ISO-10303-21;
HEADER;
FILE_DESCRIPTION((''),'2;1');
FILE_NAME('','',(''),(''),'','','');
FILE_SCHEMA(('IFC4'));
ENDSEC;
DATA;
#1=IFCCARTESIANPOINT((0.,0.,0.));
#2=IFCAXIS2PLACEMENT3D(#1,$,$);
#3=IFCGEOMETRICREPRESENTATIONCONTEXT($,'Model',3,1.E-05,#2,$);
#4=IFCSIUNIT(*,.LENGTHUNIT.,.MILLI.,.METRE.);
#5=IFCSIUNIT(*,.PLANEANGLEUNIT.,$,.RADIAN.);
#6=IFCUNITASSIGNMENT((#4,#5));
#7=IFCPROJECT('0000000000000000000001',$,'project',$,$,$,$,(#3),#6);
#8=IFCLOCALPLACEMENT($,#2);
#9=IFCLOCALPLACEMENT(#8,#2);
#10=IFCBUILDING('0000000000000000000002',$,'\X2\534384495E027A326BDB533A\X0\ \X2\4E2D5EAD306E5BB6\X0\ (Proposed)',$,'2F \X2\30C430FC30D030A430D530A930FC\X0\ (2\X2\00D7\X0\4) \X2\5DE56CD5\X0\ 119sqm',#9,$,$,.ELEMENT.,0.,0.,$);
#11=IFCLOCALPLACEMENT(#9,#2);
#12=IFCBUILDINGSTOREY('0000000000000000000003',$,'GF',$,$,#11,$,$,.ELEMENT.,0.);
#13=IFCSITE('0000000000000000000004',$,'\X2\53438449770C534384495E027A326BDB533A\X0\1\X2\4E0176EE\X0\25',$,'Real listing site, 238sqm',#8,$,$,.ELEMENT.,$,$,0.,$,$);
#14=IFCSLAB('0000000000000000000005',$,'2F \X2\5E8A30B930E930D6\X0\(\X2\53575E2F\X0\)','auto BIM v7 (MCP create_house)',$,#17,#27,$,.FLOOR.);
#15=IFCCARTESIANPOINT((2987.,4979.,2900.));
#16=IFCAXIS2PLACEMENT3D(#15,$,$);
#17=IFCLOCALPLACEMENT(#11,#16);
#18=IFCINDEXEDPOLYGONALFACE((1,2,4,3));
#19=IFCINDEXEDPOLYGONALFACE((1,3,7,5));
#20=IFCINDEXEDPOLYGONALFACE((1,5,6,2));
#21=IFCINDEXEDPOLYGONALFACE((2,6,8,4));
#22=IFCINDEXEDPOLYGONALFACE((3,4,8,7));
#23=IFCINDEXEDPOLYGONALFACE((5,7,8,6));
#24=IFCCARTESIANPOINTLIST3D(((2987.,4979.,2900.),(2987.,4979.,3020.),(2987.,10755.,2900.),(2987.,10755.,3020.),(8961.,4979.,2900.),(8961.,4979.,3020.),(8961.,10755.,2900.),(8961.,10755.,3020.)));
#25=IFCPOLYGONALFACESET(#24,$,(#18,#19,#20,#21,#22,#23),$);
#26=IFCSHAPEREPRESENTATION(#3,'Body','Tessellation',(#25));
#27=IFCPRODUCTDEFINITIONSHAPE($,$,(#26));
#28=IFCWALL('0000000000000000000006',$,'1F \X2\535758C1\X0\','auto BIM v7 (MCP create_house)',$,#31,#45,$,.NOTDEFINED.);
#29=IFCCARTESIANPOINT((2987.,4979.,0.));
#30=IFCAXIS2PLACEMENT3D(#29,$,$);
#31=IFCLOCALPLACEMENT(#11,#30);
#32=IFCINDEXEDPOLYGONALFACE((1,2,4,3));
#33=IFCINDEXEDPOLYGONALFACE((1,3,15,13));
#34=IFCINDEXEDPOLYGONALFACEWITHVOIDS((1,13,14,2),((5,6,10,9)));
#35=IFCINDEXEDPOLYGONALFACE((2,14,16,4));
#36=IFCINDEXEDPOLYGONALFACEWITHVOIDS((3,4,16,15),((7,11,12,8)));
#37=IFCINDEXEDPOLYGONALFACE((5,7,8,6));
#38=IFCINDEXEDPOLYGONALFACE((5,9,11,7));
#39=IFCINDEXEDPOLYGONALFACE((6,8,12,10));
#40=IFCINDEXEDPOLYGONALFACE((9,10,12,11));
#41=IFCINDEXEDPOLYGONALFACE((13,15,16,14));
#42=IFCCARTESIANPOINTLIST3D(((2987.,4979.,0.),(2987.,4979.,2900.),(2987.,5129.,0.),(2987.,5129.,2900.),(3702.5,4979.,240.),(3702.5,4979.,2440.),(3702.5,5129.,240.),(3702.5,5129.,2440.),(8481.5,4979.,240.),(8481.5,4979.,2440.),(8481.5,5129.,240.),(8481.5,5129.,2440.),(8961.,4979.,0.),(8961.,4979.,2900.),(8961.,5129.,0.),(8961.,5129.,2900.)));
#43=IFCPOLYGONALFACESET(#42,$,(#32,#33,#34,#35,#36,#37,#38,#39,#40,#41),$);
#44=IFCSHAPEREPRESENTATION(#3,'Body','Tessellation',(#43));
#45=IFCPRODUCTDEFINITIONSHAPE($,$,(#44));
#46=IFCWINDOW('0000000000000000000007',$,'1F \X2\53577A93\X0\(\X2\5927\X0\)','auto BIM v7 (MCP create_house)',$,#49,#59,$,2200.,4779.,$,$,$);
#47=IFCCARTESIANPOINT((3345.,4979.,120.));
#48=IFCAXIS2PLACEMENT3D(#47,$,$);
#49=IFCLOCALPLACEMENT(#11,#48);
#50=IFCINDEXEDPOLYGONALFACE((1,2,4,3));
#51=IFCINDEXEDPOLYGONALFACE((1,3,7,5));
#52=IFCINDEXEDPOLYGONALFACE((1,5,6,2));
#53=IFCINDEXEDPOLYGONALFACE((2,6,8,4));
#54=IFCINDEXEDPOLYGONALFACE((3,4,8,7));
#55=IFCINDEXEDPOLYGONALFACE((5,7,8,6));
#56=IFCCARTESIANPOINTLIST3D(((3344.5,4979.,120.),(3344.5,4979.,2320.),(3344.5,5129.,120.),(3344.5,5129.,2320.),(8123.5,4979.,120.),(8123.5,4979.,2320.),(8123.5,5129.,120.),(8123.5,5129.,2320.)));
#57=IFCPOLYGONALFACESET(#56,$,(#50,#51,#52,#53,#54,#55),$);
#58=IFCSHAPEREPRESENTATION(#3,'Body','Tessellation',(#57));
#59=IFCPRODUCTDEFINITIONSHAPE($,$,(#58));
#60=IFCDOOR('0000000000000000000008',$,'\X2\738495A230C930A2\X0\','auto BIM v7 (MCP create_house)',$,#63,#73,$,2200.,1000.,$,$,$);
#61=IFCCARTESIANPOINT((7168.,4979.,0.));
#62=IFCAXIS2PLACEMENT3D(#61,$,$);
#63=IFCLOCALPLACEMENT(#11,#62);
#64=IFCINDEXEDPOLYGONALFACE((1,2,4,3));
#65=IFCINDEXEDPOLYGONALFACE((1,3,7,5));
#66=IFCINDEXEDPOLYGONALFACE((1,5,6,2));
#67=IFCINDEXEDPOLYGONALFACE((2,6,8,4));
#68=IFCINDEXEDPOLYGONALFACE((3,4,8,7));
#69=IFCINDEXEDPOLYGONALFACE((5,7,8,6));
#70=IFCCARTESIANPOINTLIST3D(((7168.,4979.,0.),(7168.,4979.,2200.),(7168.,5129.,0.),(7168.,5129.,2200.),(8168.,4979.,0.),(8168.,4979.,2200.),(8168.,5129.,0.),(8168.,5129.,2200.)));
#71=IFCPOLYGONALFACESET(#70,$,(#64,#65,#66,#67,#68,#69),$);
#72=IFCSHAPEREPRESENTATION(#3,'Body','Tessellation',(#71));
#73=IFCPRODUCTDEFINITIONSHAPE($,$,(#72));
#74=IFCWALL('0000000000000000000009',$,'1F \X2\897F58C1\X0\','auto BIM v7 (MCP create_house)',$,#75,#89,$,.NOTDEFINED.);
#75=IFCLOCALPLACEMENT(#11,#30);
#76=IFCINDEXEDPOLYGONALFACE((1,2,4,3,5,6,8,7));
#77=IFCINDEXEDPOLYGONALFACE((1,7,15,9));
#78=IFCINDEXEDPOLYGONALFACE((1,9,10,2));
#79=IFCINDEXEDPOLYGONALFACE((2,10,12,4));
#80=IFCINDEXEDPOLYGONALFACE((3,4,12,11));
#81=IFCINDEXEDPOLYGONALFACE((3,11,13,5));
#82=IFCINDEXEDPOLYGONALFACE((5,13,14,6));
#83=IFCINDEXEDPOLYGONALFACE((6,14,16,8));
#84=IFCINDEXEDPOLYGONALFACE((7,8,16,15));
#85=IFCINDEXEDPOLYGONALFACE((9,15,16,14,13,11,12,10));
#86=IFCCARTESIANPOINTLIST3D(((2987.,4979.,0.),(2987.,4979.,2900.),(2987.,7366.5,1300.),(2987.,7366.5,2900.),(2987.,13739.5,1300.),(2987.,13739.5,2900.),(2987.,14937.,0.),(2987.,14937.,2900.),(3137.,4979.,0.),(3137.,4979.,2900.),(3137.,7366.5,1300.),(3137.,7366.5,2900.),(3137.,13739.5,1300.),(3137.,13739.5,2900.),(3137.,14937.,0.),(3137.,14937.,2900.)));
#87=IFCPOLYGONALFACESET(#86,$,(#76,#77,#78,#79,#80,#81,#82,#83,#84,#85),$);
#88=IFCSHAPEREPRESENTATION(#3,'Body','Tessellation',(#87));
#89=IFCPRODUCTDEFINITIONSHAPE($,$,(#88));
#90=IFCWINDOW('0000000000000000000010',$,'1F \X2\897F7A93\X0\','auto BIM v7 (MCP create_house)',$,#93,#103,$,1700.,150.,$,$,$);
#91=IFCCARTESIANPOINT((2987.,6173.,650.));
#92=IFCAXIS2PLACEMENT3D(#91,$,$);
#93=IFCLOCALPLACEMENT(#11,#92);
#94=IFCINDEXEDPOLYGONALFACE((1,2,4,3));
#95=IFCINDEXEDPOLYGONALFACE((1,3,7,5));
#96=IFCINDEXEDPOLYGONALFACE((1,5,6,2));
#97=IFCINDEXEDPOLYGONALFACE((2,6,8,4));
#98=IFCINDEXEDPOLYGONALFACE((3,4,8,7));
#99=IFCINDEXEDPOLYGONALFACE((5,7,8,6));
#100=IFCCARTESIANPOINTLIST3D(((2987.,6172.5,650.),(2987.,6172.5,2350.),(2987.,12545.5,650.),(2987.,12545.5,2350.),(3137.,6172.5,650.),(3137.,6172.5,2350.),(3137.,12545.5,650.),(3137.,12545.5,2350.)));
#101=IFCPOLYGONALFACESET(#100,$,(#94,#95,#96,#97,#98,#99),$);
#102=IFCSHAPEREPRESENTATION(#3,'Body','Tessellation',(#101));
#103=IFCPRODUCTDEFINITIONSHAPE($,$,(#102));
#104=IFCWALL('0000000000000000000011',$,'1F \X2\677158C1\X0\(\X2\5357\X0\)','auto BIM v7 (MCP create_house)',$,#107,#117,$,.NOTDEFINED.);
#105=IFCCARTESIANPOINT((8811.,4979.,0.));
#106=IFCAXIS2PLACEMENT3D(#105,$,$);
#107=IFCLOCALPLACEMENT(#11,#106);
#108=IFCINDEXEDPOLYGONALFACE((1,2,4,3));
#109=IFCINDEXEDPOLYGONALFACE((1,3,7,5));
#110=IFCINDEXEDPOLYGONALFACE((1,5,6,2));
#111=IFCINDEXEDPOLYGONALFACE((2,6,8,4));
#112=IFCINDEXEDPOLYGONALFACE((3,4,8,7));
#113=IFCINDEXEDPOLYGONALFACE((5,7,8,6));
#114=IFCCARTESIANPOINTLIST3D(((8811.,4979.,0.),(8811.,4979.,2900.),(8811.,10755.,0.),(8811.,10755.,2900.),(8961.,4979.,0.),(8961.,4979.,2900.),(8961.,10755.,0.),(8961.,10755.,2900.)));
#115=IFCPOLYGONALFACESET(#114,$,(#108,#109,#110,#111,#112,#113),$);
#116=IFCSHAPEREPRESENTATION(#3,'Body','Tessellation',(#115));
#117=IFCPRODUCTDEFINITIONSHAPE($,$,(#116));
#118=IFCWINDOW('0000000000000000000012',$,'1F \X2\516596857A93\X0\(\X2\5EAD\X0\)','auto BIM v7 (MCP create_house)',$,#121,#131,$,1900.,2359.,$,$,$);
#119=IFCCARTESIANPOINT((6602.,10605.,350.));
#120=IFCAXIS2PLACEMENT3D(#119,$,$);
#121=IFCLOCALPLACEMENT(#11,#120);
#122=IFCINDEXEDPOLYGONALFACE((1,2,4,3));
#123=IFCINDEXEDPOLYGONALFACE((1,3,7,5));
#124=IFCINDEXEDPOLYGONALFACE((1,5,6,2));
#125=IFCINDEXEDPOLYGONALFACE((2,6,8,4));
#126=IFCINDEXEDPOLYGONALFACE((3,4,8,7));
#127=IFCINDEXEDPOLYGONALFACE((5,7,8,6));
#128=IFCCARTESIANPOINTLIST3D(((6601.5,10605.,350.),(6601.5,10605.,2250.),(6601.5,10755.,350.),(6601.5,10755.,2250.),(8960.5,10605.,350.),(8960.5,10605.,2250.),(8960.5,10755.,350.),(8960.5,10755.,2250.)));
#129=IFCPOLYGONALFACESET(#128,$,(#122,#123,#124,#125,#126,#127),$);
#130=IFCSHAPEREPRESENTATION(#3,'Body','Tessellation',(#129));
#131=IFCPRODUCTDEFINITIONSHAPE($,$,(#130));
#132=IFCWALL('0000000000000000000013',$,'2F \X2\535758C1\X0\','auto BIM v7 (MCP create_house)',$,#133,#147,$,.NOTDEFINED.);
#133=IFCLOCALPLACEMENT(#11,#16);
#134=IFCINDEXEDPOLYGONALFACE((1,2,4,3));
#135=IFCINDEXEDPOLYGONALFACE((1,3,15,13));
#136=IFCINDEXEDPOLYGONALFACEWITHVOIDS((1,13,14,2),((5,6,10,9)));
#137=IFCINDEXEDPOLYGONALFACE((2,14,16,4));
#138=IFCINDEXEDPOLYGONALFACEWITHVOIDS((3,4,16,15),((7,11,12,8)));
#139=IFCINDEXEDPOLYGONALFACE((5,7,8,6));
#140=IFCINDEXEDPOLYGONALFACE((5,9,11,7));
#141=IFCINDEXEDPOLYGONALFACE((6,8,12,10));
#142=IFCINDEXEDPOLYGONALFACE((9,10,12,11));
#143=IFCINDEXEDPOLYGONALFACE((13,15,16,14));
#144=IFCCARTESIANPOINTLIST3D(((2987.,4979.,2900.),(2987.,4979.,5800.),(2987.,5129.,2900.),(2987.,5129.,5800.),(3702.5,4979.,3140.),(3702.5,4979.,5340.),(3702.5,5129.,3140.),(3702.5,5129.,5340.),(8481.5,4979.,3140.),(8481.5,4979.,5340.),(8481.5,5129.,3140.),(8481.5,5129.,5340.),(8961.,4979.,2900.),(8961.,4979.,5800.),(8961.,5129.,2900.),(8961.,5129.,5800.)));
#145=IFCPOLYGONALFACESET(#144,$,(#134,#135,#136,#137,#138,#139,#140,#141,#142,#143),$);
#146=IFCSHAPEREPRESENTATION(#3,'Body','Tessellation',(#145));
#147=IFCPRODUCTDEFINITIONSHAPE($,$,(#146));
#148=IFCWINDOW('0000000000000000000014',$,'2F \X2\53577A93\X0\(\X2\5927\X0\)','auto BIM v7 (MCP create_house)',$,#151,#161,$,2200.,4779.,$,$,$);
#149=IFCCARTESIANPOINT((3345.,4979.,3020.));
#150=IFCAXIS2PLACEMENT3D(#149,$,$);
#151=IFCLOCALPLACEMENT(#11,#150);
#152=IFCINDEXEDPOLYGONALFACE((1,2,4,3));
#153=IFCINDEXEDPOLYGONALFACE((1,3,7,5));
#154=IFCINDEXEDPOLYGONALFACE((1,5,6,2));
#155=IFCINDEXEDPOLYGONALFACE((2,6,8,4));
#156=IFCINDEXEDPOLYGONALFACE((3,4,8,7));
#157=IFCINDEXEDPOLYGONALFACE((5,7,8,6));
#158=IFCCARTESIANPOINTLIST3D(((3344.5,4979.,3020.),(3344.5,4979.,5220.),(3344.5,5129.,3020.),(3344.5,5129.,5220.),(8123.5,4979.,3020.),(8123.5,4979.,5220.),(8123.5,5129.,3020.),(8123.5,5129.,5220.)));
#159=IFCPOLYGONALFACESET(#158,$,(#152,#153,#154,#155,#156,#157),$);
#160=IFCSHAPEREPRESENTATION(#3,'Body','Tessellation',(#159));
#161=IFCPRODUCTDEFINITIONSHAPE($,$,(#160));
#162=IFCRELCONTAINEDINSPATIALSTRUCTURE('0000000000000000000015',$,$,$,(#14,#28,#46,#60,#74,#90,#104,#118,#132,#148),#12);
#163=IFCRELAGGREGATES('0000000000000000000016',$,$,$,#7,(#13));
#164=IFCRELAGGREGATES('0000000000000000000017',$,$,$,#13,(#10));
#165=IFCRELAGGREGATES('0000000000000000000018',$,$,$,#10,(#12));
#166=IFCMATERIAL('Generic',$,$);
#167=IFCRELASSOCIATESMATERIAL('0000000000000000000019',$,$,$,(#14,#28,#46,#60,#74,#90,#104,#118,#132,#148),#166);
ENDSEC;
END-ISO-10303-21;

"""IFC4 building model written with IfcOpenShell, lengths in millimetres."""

from ifc_helpers import new_model, si_unit, frame, frame_2d, origin, place, context, project, spatial, rectangle, extrude, material, element, fill, save


model = new_model("IFC4")

# Units and contexts
model_context = context("Model", 3, precision=1e-05, world=origin())
ifc_project = project(units=[si_unit("LENGTHUNIT", "METRE", prefix="MILLI"), si_unit("PLANEANGLEUNIT", "RADIAN")], contexts=[model_context])

# Site, building, storey
site_placement = place(None, origin())
site = spatial("IfcSite", under=ifc_project, at=site_placement, Name="千葉県千葉市稲毛区1丁目25", ObjectType="Real listing site, 238sqm", CompositionType="ELEMENT", RefElevation=0.0)
building_placement = place(site_placement, origin())
building = spatial("IfcBuilding", under=site, at=building_placement, Name="千葉市稲毛区 中庭の家 (Proposed)", ObjectType="2F ツーバイフォー (2×4) 工法 119sqm", CompositionType="ELEMENT", ElevationOfRefHeight=0.0, ElevationOfTerrain=0.0)
storey_placement = place(building_placement, origin())
storey = spatial("IfcBuildingStorey", under=building, at=storey_placement, Name="GF", CompositionType="ELEMENT", Elevation=0.0)

# Slab
ifc_material = material(Name="Generic")
slab_1_placement = place(storey_placement, frame((2987.0, 4979.0, 2900.0)))
element("IfcSlab", 1, at=slab_1_placement, inside=storey, material=ifc_material, Name="2F 床スラブ(南帯)", Description="auto BIM v7 (MCP create_house)", PredefinedType="FLOOR", context=model_context, shape_type="SweptSolid", body=[
    extrude(rectangle(XDim=5974.0, YDim=5776.0, at=frame_2d((2987.0, 2888.0))), frame((2987.0, 4979.0, 2900.0)), (0.0, 0.0, 1.0), 120.0),
])

# Wall, openings, window, door
wall_1_placement = place(storey_placement, frame((2987.0, 4979.0, 0.0)))
wall_1 = element("IfcWall", 2, at=wall_1_placement, inside=storey, material=ifc_material, Name="1F 南壁", Description="auto BIM v7 (MCP create_house)", PredefinedType="NOTDEFINED", context=model_context, shape_type="SweptSolid", body=[
    extrude(rectangle(XDim=5974.0, YDim=150.0, at=frame_2d((2987.0, 75.0))), frame((2987.0, 4979.0, 0.0)), (0.0, 0.0, 1.0), 2900.0),
])
opening_1_placement = place(storey_placement, frame((3345.0, 4979.0, 120.0)))
opening_1 = element("IfcOpeningElement", 3, at=opening_1_placement, cuts=wall_1, PredefinedType="NOTDEFINED", context=model_context, shape_type="SweptSolid", body=[
    extrude(rectangle(XDim=4779.0, YDim=150.0, at=frame_2d((2389.0, 75.0))), frame((3345.0, 4979.0, 120.0)), (0.0, 0.0, 1.0), 2200.0),
])
opening_2_placement = place(storey_placement, frame((7168.0, 4979.0, 0.0)))
opening_2 = element("IfcOpeningElement", 4, at=opening_2_placement, cuts=wall_1, PredefinedType="NOTDEFINED", context=model_context, shape_type="SweptSolid", body=[
    extrude(rectangle(XDim=1000.0, YDim=150.0, at=frame_2d((500.0, 75.0))), frame((7168.0, 4979.0, 0.0)), (0.0, 0.0, 1.0), 2200.0),
])
window_1_placement = place(storey_placement, frame((3345.0, 4979.0, 120.0)))
window_1 = element("IfcWindow", 5, at=window_1_placement, inside=storey, material=ifc_material, Name="1F 南窓(大)", Description="auto BIM v7 (MCP create_house)", OverallHeight=2200.0, OverallWidth=4779.0, context=model_context, shape_type="SweptSolid", body=[
    extrude(rectangle(XDim=4779.0, YDim=150.0, at=frame_2d((2389.0, 75.0))), frame((3345.0, 4979.0, 120.0)), (0.0, 0.0, 1.0), 2200.0),
])
fill(opening_1, window_1)
door_placement = place(storey_placement, frame((7168.0, 4979.0, 0.0)))
door = element("IfcDoor", 6, at=door_placement, inside=storey, material=ifc_material, Name="玄関ドア", Description="auto BIM v7 (MCP create_house)", OverallHeight=2200.0, OverallWidth=1000.0, context=model_context, shape_type="SweptSolid", body=[
    extrude(rectangle(XDim=1000.0, YDim=150.0, at=frame_2d((500.0, 75.0))), frame((7168.0, 4979.0, 0.0)), (0.0, 0.0, 1.0), 2200.0),
])
fill(opening_2, door)

# Walls, openings, windows
wall_2_placement = place(storey_placement, frame((2987.0, 4979.0, 0.0)))
wall_2 = element("IfcWall", 7, at=wall_2_placement, inside=storey, material=ifc_material, Name="1F 西壁", Description="auto BIM v7 (MCP create_house)", PredefinedType="NOTDEFINED", context=model_context, shape_type="SweptSolid", body=[
    extrude(rectangle(XDim=150.0, YDim=9958.0, at=frame_2d((75.0, 4979.0))), frame((2987.0, 4979.0, 0.0)), (0.0, 0.0, 1.0), 2900.0),
])
opening_3_placement = place(storey_placement, frame((2987.0, 6173.0, 650.0)))
opening_3 = element("IfcOpeningElement", 8, at=opening_3_placement, cuts=wall_2, PredefinedType="NOTDEFINED", context=model_context, shape_type="SweptSolid", body=[
    extrude(rectangle(XDim=150.0, YDim=6373.0, at=frame_2d((75.0, 3186.0))), frame((2987.0, 6173.0, 650.0)), (0.0, 0.0, 1.0), 1700.0),
])
window_2_placement = place(storey_placement, frame((2987.0, 6173.0, 650.0)))
window_2 = element("IfcWindow", 9, at=window_2_placement, inside=storey, material=ifc_material, Name="1F 西窓", Description="auto BIM v7 (MCP create_house)", OverallHeight=1700.0, OverallWidth=150.0, context=model_context, shape_type="SweptSolid", body=[
    extrude(rectangle(XDim=150.0, YDim=6373.0, at=frame_2d((75.0, 3186.0))), frame((2987.0, 6173.0, 650.0)), (0.0, 0.0, 1.0), 1700.0),
])
fill(opening_3, window_2)
wall_3_placement = place(storey_placement, frame((8811.0, 4979.0, 0.0)))
wall_3 = element("IfcWall", 10, at=wall_3_placement, inside=storey, material=ifc_material, Name="1F 東壁(南)", Description="auto BIM v7 (MCP create_house)", PredefinedType="NOTDEFINED", context=model_context, shape_type="SweptSolid", body=[
    extrude(rectangle(XDim=150.0, YDim=5776.0, at=frame_2d((75.0, 2888.0))), frame((8811.0, 4979.0, 0.0)), (0.0, 0.0, 1.0), 2900.0),
])
opening_4_placement = place(storey_placement, frame((6602.0, 10605.0, 350.0)))
opening_4 = element("IfcOpeningElement", 11, at=opening_4_placement, cuts=wall_3, PredefinedType="NOTDEFINED", context=model_context, shape_type="SweptSolid", body=[
    extrude(rectangle(XDim=2359.0, YDim=150.0, at=frame_2d((1179.0, 75.0))), frame((6602.0, 10605.0, 350.0)), (0.0, 0.0, 1.0), 1900.0),
])
window_3_placement = place(storey_placement, frame((6602.0, 10605.0, 350.0)))
window_3 = element("IfcWindow", 12, at=window_3_placement, inside=storey, material=ifc_material, Name="1F 入隅窓(庭)", Description="auto BIM v7 (MCP create_house)", OverallHeight=1900.0, OverallWidth=2359.0, context=model_context, shape_type="SweptSolid", body=[
    extrude(rectangle(XDim=2359.0, YDim=150.0, at=frame_2d((1179.0, 75.0))), frame((6602.0, 10605.0, 350.0)), (0.0, 0.0, 1.0), 1900.0),
])
fill(opening_4, window_3)

# Wall, opening, window
wall_4_placement = place(storey_placement, frame((2987.0, 4979.0, 2900.0)))
wall_4 = element("IfcWall", 13, at=wall_4_placement, inside=storey, material=ifc_material, Name="2F 南壁", Description="auto BIM v7 (MCP create_house)", PredefinedType="NOTDEFINED", context=model_context, shape_type="SweptSolid", body=[
    extrude(rectangle(XDim=5974.0, YDim=150.0, at=frame_2d((2987.0, 75.0))), frame((2987.0, 4979.0, 2900.0)), (0.0, 0.0, 1.0), 2900.0),
])
opening_5_placement = place(storey_placement, frame((3345.0, 4979.0, 3020.0)))
opening_5 = element("IfcOpeningElement", 14, at=opening_5_placement, cuts=wall_4, PredefinedType="NOTDEFINED", context=model_context, shape_type="SweptSolid", body=[
    extrude(rectangle(XDim=4779.0, YDim=150.0, at=frame_2d((2389.0, 75.0))), frame((3345.0, 4979.0, 3020.0)), (0.0, 0.0, 1.0), 2200.0),
])
window_4_placement = place(storey_placement, frame((3345.0, 4979.0, 3020.0)))
window_4 = element("IfcWindow", 15, at=window_4_placement, inside=storey, material=ifc_material, Name="2F 南窓(大)", Description="auto BIM v7 (MCP create_house)", OverallHeight=2200.0, OverallWidth=4779.0, context=model_context, shape_type="SweptSolid", body=[
    extrude(rectangle(XDim=4779.0, YDim=150.0, at=frame_2d((2389.0, 75.0))), frame((3345.0, 4979.0, 3020.0)), (0.0, 0.0, 1.0), 2200.0),
])
fill(opening_5, window_4)

save(model, "model.ifc")
